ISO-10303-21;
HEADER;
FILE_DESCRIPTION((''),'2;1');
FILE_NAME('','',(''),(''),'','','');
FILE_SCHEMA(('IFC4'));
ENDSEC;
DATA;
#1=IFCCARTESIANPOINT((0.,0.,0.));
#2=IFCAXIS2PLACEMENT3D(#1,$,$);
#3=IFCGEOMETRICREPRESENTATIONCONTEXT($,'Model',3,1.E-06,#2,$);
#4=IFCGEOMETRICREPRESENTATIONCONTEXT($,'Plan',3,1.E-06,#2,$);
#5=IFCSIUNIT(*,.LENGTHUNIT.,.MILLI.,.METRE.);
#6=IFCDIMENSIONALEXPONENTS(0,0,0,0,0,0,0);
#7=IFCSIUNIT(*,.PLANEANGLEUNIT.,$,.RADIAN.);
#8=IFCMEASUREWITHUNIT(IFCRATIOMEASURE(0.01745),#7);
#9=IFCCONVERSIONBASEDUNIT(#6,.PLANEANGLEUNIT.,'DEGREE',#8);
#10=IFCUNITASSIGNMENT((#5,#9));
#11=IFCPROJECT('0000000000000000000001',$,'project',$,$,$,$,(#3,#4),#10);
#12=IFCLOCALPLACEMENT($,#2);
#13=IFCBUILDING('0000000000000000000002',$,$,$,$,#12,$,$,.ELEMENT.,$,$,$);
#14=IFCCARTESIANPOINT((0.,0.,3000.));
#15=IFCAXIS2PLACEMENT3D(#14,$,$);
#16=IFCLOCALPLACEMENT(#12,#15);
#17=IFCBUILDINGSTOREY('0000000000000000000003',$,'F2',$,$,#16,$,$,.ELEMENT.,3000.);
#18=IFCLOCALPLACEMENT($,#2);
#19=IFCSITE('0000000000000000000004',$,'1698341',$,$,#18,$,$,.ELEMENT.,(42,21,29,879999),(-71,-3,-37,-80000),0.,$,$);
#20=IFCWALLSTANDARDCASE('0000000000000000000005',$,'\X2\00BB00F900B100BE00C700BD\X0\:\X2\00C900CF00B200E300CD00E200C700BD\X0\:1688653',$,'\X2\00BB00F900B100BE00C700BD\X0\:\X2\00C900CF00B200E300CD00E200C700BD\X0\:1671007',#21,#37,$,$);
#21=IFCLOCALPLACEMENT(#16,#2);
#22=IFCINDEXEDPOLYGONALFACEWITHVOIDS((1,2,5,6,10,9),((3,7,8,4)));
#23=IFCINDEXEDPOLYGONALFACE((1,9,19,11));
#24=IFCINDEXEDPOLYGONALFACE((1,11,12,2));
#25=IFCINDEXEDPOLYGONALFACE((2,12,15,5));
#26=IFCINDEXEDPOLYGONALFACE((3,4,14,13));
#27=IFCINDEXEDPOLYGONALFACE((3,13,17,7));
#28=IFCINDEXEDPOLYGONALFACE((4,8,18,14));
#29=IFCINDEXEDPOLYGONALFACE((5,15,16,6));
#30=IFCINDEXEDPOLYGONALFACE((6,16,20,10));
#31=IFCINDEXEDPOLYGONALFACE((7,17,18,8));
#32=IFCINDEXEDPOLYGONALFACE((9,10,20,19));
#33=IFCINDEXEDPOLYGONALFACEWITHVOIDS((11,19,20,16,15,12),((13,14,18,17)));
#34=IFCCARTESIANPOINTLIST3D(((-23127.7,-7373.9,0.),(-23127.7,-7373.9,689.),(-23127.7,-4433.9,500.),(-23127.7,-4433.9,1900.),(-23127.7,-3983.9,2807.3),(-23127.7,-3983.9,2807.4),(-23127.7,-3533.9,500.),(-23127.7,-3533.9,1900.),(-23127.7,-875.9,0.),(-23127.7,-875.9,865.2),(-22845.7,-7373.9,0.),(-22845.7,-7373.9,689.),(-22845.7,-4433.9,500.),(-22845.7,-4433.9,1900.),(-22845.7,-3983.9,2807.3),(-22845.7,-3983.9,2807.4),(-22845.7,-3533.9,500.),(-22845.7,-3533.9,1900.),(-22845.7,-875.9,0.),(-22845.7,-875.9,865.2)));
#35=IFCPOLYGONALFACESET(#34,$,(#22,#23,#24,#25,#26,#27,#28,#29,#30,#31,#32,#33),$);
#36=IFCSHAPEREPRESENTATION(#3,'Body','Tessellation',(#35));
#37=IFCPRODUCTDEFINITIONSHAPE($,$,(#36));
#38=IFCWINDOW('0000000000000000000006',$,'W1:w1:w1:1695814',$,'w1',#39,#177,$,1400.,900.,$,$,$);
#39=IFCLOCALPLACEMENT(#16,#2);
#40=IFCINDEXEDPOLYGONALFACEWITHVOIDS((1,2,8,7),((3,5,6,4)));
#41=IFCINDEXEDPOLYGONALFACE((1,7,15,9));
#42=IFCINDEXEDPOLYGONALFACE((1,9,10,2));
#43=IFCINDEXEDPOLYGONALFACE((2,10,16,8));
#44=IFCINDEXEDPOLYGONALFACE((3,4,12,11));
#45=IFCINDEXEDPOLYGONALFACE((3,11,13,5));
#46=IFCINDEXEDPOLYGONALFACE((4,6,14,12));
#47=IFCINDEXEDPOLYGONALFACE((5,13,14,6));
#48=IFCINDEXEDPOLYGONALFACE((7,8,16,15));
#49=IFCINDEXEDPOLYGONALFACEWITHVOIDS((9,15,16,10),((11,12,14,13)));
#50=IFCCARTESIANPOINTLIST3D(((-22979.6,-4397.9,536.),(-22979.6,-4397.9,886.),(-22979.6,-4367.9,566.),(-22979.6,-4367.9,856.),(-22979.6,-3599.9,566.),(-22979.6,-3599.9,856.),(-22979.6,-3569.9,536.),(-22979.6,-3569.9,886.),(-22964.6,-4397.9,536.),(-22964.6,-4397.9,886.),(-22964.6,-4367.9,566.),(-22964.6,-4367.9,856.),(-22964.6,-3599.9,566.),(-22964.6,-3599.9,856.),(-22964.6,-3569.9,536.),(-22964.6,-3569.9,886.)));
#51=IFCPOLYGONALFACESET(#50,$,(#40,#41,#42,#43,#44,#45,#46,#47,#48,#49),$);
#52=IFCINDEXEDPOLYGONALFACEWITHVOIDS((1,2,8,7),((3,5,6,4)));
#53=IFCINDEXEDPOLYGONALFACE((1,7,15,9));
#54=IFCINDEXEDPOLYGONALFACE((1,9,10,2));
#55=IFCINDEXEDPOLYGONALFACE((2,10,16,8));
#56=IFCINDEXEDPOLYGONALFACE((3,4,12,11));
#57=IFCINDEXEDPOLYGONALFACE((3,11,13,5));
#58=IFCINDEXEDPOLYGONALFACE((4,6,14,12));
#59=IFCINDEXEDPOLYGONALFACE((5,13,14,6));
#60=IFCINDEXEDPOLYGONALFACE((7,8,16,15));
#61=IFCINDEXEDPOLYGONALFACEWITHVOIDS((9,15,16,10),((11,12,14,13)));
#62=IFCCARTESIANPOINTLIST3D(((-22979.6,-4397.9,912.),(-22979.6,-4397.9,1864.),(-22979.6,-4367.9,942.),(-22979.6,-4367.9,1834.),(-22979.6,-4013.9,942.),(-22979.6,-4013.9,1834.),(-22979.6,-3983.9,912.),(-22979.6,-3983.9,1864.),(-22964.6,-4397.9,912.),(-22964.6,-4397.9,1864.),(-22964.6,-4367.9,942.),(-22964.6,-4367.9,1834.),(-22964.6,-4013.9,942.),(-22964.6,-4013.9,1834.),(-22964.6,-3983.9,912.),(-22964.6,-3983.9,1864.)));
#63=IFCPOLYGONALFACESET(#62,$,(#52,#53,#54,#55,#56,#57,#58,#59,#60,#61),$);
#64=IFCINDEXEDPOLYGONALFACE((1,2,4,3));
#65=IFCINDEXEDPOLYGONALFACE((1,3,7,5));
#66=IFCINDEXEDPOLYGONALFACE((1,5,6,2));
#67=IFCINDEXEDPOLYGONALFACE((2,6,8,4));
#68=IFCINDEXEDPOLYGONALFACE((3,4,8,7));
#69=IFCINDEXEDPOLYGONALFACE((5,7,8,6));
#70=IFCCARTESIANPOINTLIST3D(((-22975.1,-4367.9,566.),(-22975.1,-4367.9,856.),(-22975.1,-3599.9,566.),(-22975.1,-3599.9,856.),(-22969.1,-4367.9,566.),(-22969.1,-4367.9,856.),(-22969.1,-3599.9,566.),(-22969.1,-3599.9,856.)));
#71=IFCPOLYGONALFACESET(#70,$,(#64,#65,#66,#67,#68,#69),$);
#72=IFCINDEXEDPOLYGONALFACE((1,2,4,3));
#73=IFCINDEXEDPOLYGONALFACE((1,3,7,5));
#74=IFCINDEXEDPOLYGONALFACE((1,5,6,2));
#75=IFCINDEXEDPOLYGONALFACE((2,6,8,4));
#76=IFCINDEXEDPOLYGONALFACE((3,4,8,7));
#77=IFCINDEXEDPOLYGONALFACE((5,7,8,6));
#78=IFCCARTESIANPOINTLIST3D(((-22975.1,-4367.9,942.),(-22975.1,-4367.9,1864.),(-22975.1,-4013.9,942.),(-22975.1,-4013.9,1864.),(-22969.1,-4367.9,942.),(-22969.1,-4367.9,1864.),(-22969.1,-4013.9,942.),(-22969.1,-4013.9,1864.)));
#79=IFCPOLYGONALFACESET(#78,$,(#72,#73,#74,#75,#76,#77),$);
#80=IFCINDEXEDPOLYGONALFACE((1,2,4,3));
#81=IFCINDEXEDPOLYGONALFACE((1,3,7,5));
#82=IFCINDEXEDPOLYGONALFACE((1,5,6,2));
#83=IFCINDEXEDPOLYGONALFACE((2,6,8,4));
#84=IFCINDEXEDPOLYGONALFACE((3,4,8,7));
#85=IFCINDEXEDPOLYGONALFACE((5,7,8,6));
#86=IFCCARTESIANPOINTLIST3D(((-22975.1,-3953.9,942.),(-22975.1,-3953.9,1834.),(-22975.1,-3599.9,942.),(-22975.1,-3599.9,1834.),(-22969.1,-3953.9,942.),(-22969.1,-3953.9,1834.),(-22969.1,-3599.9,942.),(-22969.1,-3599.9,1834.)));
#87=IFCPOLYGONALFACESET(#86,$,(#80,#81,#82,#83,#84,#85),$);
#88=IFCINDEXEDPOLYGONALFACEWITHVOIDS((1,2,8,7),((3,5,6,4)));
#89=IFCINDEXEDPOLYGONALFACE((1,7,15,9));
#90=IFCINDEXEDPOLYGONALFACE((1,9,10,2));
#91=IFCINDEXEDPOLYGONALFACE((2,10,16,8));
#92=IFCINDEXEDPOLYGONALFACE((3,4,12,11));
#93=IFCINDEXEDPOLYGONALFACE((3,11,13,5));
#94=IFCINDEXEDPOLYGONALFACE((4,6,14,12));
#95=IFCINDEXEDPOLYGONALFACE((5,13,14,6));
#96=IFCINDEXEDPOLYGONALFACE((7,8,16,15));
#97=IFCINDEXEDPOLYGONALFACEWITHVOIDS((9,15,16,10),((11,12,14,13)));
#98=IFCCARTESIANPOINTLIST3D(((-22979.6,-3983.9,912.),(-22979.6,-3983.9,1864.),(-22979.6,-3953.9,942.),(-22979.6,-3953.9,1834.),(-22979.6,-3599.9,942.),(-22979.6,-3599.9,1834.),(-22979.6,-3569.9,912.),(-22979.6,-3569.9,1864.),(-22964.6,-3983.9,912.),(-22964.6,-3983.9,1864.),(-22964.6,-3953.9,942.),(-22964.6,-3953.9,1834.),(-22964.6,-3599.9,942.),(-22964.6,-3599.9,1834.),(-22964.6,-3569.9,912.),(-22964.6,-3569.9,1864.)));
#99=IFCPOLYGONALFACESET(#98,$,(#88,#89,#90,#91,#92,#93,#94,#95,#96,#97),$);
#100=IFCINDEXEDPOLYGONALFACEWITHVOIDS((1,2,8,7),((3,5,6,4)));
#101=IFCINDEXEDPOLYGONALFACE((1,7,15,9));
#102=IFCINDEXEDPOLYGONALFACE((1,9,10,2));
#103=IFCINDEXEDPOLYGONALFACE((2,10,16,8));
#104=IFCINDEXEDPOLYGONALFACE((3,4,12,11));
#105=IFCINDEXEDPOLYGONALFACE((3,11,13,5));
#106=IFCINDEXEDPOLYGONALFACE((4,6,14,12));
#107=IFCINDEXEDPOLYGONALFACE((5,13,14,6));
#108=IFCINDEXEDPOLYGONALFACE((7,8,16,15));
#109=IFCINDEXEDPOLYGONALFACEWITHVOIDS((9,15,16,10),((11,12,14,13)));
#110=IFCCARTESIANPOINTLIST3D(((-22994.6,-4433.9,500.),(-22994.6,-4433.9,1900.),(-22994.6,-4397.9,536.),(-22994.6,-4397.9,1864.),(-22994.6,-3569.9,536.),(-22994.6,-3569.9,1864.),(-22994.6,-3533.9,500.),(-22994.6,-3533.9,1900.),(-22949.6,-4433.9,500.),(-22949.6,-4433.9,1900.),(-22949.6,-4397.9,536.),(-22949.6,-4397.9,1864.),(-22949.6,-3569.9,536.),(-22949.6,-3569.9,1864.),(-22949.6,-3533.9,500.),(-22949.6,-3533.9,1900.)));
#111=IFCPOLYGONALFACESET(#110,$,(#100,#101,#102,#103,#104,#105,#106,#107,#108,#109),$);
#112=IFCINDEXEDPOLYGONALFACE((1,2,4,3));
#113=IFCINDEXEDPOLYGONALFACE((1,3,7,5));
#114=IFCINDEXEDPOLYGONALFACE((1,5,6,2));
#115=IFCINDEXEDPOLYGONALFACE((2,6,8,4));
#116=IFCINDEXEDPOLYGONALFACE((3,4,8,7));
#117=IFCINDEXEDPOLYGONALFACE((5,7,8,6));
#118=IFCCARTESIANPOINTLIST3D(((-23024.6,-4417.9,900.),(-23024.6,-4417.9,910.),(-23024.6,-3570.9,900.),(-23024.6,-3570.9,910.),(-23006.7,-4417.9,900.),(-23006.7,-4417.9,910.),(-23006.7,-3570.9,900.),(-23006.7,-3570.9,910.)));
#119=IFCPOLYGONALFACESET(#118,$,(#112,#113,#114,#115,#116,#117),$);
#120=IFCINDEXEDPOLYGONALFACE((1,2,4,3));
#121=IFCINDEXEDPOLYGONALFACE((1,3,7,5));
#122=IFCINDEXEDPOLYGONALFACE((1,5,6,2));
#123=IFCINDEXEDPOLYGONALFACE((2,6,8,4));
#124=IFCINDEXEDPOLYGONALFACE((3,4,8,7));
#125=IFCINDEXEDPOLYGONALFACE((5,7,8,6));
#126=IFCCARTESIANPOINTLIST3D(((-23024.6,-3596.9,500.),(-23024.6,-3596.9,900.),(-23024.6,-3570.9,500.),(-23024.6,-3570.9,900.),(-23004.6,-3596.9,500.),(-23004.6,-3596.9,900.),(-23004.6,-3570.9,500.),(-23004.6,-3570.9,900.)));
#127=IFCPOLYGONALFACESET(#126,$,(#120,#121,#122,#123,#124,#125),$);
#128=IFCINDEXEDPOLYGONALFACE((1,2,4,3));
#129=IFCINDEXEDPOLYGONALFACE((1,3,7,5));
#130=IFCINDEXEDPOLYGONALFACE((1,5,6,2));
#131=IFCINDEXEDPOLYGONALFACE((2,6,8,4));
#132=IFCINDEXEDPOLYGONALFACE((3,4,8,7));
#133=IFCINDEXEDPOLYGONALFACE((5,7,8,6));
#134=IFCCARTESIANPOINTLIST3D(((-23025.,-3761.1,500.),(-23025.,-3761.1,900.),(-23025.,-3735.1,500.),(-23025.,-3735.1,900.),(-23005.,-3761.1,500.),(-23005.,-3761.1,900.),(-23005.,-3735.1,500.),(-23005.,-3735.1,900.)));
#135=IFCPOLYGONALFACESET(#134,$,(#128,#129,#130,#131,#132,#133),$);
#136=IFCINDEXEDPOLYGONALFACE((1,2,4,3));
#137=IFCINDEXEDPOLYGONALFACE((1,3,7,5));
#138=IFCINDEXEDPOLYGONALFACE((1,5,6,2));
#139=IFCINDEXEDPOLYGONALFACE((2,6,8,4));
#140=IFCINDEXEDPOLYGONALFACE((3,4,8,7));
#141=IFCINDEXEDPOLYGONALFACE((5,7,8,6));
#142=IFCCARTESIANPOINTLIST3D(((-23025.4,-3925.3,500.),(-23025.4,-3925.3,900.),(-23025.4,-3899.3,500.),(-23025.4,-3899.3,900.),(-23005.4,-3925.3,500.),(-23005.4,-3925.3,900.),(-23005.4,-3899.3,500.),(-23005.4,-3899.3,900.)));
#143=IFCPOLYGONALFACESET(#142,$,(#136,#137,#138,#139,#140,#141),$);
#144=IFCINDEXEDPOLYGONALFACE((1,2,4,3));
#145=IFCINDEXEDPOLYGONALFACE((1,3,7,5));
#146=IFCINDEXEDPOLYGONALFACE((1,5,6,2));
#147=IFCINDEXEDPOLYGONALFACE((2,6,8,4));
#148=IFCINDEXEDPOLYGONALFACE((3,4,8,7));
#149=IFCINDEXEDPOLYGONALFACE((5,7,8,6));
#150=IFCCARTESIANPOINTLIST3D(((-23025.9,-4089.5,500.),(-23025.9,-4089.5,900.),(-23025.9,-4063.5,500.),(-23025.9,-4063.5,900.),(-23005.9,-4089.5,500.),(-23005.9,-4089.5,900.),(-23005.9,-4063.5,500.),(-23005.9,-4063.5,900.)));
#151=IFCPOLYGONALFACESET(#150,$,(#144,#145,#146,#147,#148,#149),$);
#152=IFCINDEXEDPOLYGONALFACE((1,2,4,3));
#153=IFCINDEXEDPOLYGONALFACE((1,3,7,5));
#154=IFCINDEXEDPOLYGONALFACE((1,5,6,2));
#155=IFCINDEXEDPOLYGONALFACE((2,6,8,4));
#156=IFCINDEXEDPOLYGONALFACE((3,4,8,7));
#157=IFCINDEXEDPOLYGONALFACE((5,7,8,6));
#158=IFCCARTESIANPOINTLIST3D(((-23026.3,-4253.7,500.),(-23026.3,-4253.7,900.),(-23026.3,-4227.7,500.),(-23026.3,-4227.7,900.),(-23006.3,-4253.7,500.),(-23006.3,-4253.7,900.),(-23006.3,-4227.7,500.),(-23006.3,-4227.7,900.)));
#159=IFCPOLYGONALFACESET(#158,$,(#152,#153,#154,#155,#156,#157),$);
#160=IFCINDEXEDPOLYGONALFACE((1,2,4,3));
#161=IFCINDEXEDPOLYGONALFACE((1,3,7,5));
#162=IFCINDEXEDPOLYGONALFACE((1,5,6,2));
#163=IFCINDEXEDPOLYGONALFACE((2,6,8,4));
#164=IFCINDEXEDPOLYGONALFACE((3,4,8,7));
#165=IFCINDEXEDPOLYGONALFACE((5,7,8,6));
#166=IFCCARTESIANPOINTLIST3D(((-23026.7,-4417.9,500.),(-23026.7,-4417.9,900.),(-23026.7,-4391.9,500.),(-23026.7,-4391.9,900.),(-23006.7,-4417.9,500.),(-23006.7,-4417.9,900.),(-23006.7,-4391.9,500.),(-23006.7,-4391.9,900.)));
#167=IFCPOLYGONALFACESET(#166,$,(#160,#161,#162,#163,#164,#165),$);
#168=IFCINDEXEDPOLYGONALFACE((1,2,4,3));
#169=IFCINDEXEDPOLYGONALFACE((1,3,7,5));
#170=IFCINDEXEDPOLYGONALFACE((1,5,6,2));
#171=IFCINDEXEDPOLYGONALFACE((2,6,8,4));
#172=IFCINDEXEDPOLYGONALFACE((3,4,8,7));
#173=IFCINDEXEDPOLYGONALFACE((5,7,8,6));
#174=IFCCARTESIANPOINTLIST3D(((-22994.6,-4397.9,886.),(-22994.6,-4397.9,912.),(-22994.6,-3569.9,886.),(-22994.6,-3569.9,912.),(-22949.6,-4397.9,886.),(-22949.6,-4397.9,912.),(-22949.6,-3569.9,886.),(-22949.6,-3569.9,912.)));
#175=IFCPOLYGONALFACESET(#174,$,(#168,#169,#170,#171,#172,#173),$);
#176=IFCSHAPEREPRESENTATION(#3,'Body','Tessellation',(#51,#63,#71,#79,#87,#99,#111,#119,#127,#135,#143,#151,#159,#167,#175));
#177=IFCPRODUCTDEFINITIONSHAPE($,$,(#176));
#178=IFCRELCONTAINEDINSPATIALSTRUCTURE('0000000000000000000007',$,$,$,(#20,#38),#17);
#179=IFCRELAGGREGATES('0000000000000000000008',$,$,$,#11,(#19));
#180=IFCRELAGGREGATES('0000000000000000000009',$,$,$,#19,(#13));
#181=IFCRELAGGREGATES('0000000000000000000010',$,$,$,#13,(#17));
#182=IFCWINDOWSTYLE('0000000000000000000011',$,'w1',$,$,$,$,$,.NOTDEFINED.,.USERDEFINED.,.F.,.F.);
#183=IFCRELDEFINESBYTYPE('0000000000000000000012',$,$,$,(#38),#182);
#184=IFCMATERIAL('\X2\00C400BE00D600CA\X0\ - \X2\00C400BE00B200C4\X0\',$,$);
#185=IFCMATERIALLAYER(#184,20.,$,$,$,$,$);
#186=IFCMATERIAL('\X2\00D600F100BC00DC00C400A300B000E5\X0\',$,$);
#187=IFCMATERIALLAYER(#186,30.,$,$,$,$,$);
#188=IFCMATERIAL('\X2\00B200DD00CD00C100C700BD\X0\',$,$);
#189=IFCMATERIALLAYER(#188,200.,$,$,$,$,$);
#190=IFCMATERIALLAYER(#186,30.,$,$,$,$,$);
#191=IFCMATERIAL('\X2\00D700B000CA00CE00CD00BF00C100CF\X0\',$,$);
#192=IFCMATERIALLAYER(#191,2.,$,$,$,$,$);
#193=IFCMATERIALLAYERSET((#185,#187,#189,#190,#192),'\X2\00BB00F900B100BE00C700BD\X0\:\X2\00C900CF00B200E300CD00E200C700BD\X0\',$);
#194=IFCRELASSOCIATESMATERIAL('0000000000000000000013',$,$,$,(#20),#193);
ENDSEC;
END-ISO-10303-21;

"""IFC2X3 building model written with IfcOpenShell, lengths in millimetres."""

from ifc_helpers import new_model, entity, si_unit, converted_unit, frame, frame_2d, origin, origin_2d_with_axis, place, context, project, spatial, polyline, rectangle, outline, extrude, clip, bounded_halfspace, source, transform, mapped, material, layer, layer_set, layer_usage, type_object, type_shapes, element, fill, save


model = new_model("IFC2X3")

# Units and contexts
model_context = context("Model", 3, precision=1e-06, world=origin())
plan_context = context("Plan", 3, precision=1e-06, world=origin())
ifc_project = project(units=[si_unit("LENGTHUNIT", "METRE", prefix="MILLI"), converted_unit("PLANEANGLEUNIT", "DEGREE", entity("IfcRatioMeasure", 0.01745), si_unit("PLANEANGLEUNIT", "RADIAN"), dimensions=[0, 0, 0, 0, 0, 0, 0])], contexts=[model_context, plan_context])

# Site, building, storey
site_placement = place(None, origin())
site = spatial("IfcSite", under=ifc_project, at=site_placement, Name="1698341", CompositionType="ELEMENT", RefLatitude=(42, 21, 29, 879999), RefLongitude=(-71, -3, -37, -80000), RefElevation=0.0)
building_placement = place(None, origin())
building = spatial("IfcBuilding", under=site, at=building_placement, CompositionType="ELEMENT")
storey_placement = place(building_placement, frame((0.0, 0.0, 3000.0)))
storey = spatial("IfcBuildingStorey", under=building, at=storey_placement, Name="F2", CompositionType="ELEMENT", Elevation=3000.0)

# Shared definitions
ifc_material_1 = material(Name="Öñ¼ÜÄ£°å")

# Shared definitions
ifc_material_2 = material(Name="Ä¾ÖÊ - Ä¾²Ä")
ifc_layer_1 = layer(ifc_material_2, 20.0)
ifc_layer_2 = layer(ifc_material_1, 30.0)
ifc_material_3 = material(Name="²ÝÍÁÇ½")
ifc_layer_3 = layer(ifc_material_3, 200.0)
ifc_layer_4 = layer(ifc_material_1, 30.0)
ifc_material_4 = material(Name="×°ÊÎÍ¿ÁÏ")
ifc_layer_5 = layer(ifc_material_4, 2.0)
ifc_layer_set_1 = layer_set([ifc_layer_1, ifc_layer_2, ifc_layer_3, ifc_layer_4, ifc_layer_5], Name="»ù±¾Ç½:ÉÏ²ãÍâÇ½")

# Wall, opening, window
ifc_layer_usage_1 = layer_usage(ifc_layer_set_1, "AXIS2", "NEGATIVE", 141.0)
wall_1_placement = place(storey_placement, frame((-22986.7, -875.9, 0.0), z_axis=(0.0, 0.0, 1.0), x_axis=(0.0, -1.0, 0.0)))
wall_1 = element("IfcWallStandardCase", 1, at=wall_1_placement, inside=storey, material=ifc_layer_usage_1, Name="»ù±¾Ç½:ÉÏ²ãÍâÇ½:1688653", ObjectType="»ù±¾Ç½:ÉÏ²ãÍâÇ½:1671007", context=model_context, shape_type="Clipping", body=[
    clip(clip(extrude(rectangle(XDim=6498.0, YDim=282.0, at=frame_2d((3249.0, 0.0), x_axis=(-1.0, 0.0))), origin(), (0.0, 0.0, 1.0), 3200.0), bounded_halfspace(frame((0.0, -141.0, 865.2), z_axis=(-0.5299, 0.0, 0.848), x_axis=(0.0, -1.0, 0.0)), False, frame((0.0, -141.0, 865.2)), polyline([(0.0, 0.0), (3108.0, 0.0), (3108.0, 282.0), (0.0, 282.0), (0.0, 0.0)]))), bounded_halfspace(frame((3108.0, -141.0, 2807.3), z_axis=(0.5299, 0.0, 0.848), x_axis=(0.0, 1.0, 0.0)), False, frame((3108.0, -141.0, 2807.3)), polyline([(0.0, 0.0), (3390.0, 0.0), (3390.0, 282.0), (0.0, 282.0), (0.0, 0.0)]))),
])
opening_1_placement = place(wall_1_placement, frame((2658.0, -141.0, 500.0)))
opening_1 = element("IfcOpeningElement", 2, at=opening_1_placement, cuts=wall_1, ObjectType="Opening", context=model_context, shape_type="SweptSolid", body=[
    extrude(rectangle(XDim=1400.0, YDim=900.0, at=frame_2d((700.0, 450.0), x_axis=(-1.0, 0.0))), frame((0.0, 0.0, 0.0), z_axis=(0.0, 1.0, 0.0), x_axis=(0.0, 0.0, 1.0)), (0.0, 0.0, 1.0), 282.0),
])
window_style_1 = type_object("IfcWindowStyle", Name="w1", ConstructionType="NOTDEFINED", OperationType="USERDEFINED", ParameterTakesPrecedence=False, Sizeable=False)
shared_shape_1 = source(origin(), model_context, "Body", "SweptSolid", [
    extrude(outline(polyline([(-414.0, -175.0), (414.0, -175.0), (414.0, 175.0), (-414.0, 175.0), (-414.0, -175.0)]), holes=[polyline([(-384.0, 145.0), (384.0, 145.0), (384.0, -145.0), (-384.0, -145.0), (-384.0, 145.0)])]), frame((-202.3, 158.8, 211.0), z_axis=(0.0, -1.0, 0.0), x_axis=(-1.0, 0.0, 0.0)), (0.0, 0.0, 1.0), 15.0),
    extrude(outline(polyline([(-207.0, -476.0), (207.0, -476.0), (207.0, 476.0), (-207.0, 476.0), (-207.0, -476.0)]), holes=[polyline([(-177.0, 446.0), (177.0, 446.0), (177.0, -446.0), (-177.0, -446.0), (-177.0, 446.0)])]), frame((4.7, 158.8, 888.0), z_axis=(0.0, -1.0, 0.0), x_axis=(-1.0, 0.0, 0.0)), (0.0, 0.0, 1.0), 15.0),
    extrude(rectangle(XDim=768.0, YDim=6.0, at=origin_2d_with_axis()), frame((-202.3, 151.3, 66.0)), (0.0, 0.0, 1.0), 290.0),
    extrude(rectangle(XDim=354.0, YDim=6.0, at=origin_2d_with_axis()), frame((4.7, 151.3, 442.0)), (0.0, 0.0, 1.0), 922.0),
    extrude(rectangle(XDim=354.0, YDim=6.0, at=origin_2d_with_axis()), frame((-409.3, 151.3, 442.0)), (0.0, 0.0, 1.0), 892.0),
    extrude(outline(polyline([(-207.0, -476.0), (207.0, -476.0), (207.0, 476.0), (-207.0, 476.0), (-207.0, -476.0)]), holes=[polyline([(-177.0, 446.0), (177.0, 446.0), (177.0, -446.0), (-177.0, -446.0), (-177.0, 446.0)])]), frame((-409.3, 158.8, 888.0), z_axis=(0.0, -1.0, 0.0), x_axis=(-1.0, 0.0, 0.0)), (0.0, 0.0, 1.0), 15.0),
    extrude(outline(polyline([(-450.0, -700.0), (450.0, -700.0), (450.0, 700.0), (-450.0, 700.0), (-450.0, -700.0)]), holes=[polyline([(-414.0, 664.0), (414.0, 664.0), (414.0, -664.0), (-414.0, -664.0), (-414.0, 664.0)])]), frame((-202.3, 173.9, 700.0), z_axis=(0.0, -1.0, 0.0), x_axis=(-1.0, 0.0, 0.0)), (0.0, 0.0, 1.0), 45.0),
    extrude(rectangle(XDim=17.9, YDim=847.1, at=origin_2d_with_axis()), frame((-191.8, 107.8, 400.0), z_axis=(0.0, 0.0, 1.0), x_axis=(0.0, -1.0, 0.0)), (0.0, 0.0, 1.0), 10.0),
    extrude(rectangle(XDim=20.0, YDim=26.0, at=origin_2d_with_axis()), frame((-602.3, 108.9, 0.0), z_axis=(0.0, 0.0, 1.0), x_axis=(0.0, -1.0, 0.0)), (0.0, 0.0, 1.0), 400.0),
    extrude(rectangle(XDim=20.0, YDim=26.0, at=origin_2d_with_axis()), frame((-438.1, 108.4, 0.0), z_axis=(0.0, 0.0, 1.0), x_axis=(0.0, -1.0, 0.0)), (0.0, 0.0, 1.0), 400.0),
    extrude(rectangle(XDim=20.0, YDim=26.0, at=origin_2d_with_axis()), frame((-273.9, 108.0, 0.0), z_axis=(0.0, 0.0, 1.0), x_axis=(0.0, -1.0, 0.0)), (0.0, 0.0, 1.0), 400.0),
    extrude(rectangle(XDim=20.0, YDim=26.0, at=origin_2d_with_axis()), frame((-109.7, 107.6, 0.0), z_axis=(0.0, 0.0, 1.0), x_axis=(0.0, -1.0, 0.0)), (0.0, 0.0, 1.0), 400.0),
    extrude(rectangle(XDim=20.0, YDim=26.0, at=origin_2d_with_axis()), frame((54.5, 107.1, 0.0), z_axis=(0.0, 0.0, 1.0), x_axis=(0.0, -1.0, 0.0)), (0.0, 0.0, 1.0), 400.0),
    extrude(rectangle(XDim=20.0, YDim=26.0, at=origin_2d_with_axis()), frame((218.7, 106.7, 0.0), z_axis=(0.0, 0.0, 1.0), x_axis=(0.0, -1.0, 0.0)), (0.0, 0.0, 1.0), 400.0),
    extrude(rectangle(XDim=828.0, YDim=45.0, at=origin_2d_with_axis()), frame((-202.3, 151.3, 386.0)), (0.0, 0.0, 1.0), 26.0),
])
type_shapes(window_style_1, [shared_shape_1])
window_1_placement = place(opening_1_placement, frame((652.3, 4.3, 0.0)))
window_1 = element("IfcWindow", 3, at=window_1_placement, inside=storey, type_object=window_style_1, Name="W1:w1:w1:1695814", ObjectType="w1", OverallHeight=1400.0, OverallWidth=900.0, context=model_context, shape_type="MappedRepresentation", body=[
    mapped(shared_shape_1, transform((0.0, 0.0, 0.0), scale=1.0)),
])
fill(opening_1, window_1)

save(model, "model.ifc")
